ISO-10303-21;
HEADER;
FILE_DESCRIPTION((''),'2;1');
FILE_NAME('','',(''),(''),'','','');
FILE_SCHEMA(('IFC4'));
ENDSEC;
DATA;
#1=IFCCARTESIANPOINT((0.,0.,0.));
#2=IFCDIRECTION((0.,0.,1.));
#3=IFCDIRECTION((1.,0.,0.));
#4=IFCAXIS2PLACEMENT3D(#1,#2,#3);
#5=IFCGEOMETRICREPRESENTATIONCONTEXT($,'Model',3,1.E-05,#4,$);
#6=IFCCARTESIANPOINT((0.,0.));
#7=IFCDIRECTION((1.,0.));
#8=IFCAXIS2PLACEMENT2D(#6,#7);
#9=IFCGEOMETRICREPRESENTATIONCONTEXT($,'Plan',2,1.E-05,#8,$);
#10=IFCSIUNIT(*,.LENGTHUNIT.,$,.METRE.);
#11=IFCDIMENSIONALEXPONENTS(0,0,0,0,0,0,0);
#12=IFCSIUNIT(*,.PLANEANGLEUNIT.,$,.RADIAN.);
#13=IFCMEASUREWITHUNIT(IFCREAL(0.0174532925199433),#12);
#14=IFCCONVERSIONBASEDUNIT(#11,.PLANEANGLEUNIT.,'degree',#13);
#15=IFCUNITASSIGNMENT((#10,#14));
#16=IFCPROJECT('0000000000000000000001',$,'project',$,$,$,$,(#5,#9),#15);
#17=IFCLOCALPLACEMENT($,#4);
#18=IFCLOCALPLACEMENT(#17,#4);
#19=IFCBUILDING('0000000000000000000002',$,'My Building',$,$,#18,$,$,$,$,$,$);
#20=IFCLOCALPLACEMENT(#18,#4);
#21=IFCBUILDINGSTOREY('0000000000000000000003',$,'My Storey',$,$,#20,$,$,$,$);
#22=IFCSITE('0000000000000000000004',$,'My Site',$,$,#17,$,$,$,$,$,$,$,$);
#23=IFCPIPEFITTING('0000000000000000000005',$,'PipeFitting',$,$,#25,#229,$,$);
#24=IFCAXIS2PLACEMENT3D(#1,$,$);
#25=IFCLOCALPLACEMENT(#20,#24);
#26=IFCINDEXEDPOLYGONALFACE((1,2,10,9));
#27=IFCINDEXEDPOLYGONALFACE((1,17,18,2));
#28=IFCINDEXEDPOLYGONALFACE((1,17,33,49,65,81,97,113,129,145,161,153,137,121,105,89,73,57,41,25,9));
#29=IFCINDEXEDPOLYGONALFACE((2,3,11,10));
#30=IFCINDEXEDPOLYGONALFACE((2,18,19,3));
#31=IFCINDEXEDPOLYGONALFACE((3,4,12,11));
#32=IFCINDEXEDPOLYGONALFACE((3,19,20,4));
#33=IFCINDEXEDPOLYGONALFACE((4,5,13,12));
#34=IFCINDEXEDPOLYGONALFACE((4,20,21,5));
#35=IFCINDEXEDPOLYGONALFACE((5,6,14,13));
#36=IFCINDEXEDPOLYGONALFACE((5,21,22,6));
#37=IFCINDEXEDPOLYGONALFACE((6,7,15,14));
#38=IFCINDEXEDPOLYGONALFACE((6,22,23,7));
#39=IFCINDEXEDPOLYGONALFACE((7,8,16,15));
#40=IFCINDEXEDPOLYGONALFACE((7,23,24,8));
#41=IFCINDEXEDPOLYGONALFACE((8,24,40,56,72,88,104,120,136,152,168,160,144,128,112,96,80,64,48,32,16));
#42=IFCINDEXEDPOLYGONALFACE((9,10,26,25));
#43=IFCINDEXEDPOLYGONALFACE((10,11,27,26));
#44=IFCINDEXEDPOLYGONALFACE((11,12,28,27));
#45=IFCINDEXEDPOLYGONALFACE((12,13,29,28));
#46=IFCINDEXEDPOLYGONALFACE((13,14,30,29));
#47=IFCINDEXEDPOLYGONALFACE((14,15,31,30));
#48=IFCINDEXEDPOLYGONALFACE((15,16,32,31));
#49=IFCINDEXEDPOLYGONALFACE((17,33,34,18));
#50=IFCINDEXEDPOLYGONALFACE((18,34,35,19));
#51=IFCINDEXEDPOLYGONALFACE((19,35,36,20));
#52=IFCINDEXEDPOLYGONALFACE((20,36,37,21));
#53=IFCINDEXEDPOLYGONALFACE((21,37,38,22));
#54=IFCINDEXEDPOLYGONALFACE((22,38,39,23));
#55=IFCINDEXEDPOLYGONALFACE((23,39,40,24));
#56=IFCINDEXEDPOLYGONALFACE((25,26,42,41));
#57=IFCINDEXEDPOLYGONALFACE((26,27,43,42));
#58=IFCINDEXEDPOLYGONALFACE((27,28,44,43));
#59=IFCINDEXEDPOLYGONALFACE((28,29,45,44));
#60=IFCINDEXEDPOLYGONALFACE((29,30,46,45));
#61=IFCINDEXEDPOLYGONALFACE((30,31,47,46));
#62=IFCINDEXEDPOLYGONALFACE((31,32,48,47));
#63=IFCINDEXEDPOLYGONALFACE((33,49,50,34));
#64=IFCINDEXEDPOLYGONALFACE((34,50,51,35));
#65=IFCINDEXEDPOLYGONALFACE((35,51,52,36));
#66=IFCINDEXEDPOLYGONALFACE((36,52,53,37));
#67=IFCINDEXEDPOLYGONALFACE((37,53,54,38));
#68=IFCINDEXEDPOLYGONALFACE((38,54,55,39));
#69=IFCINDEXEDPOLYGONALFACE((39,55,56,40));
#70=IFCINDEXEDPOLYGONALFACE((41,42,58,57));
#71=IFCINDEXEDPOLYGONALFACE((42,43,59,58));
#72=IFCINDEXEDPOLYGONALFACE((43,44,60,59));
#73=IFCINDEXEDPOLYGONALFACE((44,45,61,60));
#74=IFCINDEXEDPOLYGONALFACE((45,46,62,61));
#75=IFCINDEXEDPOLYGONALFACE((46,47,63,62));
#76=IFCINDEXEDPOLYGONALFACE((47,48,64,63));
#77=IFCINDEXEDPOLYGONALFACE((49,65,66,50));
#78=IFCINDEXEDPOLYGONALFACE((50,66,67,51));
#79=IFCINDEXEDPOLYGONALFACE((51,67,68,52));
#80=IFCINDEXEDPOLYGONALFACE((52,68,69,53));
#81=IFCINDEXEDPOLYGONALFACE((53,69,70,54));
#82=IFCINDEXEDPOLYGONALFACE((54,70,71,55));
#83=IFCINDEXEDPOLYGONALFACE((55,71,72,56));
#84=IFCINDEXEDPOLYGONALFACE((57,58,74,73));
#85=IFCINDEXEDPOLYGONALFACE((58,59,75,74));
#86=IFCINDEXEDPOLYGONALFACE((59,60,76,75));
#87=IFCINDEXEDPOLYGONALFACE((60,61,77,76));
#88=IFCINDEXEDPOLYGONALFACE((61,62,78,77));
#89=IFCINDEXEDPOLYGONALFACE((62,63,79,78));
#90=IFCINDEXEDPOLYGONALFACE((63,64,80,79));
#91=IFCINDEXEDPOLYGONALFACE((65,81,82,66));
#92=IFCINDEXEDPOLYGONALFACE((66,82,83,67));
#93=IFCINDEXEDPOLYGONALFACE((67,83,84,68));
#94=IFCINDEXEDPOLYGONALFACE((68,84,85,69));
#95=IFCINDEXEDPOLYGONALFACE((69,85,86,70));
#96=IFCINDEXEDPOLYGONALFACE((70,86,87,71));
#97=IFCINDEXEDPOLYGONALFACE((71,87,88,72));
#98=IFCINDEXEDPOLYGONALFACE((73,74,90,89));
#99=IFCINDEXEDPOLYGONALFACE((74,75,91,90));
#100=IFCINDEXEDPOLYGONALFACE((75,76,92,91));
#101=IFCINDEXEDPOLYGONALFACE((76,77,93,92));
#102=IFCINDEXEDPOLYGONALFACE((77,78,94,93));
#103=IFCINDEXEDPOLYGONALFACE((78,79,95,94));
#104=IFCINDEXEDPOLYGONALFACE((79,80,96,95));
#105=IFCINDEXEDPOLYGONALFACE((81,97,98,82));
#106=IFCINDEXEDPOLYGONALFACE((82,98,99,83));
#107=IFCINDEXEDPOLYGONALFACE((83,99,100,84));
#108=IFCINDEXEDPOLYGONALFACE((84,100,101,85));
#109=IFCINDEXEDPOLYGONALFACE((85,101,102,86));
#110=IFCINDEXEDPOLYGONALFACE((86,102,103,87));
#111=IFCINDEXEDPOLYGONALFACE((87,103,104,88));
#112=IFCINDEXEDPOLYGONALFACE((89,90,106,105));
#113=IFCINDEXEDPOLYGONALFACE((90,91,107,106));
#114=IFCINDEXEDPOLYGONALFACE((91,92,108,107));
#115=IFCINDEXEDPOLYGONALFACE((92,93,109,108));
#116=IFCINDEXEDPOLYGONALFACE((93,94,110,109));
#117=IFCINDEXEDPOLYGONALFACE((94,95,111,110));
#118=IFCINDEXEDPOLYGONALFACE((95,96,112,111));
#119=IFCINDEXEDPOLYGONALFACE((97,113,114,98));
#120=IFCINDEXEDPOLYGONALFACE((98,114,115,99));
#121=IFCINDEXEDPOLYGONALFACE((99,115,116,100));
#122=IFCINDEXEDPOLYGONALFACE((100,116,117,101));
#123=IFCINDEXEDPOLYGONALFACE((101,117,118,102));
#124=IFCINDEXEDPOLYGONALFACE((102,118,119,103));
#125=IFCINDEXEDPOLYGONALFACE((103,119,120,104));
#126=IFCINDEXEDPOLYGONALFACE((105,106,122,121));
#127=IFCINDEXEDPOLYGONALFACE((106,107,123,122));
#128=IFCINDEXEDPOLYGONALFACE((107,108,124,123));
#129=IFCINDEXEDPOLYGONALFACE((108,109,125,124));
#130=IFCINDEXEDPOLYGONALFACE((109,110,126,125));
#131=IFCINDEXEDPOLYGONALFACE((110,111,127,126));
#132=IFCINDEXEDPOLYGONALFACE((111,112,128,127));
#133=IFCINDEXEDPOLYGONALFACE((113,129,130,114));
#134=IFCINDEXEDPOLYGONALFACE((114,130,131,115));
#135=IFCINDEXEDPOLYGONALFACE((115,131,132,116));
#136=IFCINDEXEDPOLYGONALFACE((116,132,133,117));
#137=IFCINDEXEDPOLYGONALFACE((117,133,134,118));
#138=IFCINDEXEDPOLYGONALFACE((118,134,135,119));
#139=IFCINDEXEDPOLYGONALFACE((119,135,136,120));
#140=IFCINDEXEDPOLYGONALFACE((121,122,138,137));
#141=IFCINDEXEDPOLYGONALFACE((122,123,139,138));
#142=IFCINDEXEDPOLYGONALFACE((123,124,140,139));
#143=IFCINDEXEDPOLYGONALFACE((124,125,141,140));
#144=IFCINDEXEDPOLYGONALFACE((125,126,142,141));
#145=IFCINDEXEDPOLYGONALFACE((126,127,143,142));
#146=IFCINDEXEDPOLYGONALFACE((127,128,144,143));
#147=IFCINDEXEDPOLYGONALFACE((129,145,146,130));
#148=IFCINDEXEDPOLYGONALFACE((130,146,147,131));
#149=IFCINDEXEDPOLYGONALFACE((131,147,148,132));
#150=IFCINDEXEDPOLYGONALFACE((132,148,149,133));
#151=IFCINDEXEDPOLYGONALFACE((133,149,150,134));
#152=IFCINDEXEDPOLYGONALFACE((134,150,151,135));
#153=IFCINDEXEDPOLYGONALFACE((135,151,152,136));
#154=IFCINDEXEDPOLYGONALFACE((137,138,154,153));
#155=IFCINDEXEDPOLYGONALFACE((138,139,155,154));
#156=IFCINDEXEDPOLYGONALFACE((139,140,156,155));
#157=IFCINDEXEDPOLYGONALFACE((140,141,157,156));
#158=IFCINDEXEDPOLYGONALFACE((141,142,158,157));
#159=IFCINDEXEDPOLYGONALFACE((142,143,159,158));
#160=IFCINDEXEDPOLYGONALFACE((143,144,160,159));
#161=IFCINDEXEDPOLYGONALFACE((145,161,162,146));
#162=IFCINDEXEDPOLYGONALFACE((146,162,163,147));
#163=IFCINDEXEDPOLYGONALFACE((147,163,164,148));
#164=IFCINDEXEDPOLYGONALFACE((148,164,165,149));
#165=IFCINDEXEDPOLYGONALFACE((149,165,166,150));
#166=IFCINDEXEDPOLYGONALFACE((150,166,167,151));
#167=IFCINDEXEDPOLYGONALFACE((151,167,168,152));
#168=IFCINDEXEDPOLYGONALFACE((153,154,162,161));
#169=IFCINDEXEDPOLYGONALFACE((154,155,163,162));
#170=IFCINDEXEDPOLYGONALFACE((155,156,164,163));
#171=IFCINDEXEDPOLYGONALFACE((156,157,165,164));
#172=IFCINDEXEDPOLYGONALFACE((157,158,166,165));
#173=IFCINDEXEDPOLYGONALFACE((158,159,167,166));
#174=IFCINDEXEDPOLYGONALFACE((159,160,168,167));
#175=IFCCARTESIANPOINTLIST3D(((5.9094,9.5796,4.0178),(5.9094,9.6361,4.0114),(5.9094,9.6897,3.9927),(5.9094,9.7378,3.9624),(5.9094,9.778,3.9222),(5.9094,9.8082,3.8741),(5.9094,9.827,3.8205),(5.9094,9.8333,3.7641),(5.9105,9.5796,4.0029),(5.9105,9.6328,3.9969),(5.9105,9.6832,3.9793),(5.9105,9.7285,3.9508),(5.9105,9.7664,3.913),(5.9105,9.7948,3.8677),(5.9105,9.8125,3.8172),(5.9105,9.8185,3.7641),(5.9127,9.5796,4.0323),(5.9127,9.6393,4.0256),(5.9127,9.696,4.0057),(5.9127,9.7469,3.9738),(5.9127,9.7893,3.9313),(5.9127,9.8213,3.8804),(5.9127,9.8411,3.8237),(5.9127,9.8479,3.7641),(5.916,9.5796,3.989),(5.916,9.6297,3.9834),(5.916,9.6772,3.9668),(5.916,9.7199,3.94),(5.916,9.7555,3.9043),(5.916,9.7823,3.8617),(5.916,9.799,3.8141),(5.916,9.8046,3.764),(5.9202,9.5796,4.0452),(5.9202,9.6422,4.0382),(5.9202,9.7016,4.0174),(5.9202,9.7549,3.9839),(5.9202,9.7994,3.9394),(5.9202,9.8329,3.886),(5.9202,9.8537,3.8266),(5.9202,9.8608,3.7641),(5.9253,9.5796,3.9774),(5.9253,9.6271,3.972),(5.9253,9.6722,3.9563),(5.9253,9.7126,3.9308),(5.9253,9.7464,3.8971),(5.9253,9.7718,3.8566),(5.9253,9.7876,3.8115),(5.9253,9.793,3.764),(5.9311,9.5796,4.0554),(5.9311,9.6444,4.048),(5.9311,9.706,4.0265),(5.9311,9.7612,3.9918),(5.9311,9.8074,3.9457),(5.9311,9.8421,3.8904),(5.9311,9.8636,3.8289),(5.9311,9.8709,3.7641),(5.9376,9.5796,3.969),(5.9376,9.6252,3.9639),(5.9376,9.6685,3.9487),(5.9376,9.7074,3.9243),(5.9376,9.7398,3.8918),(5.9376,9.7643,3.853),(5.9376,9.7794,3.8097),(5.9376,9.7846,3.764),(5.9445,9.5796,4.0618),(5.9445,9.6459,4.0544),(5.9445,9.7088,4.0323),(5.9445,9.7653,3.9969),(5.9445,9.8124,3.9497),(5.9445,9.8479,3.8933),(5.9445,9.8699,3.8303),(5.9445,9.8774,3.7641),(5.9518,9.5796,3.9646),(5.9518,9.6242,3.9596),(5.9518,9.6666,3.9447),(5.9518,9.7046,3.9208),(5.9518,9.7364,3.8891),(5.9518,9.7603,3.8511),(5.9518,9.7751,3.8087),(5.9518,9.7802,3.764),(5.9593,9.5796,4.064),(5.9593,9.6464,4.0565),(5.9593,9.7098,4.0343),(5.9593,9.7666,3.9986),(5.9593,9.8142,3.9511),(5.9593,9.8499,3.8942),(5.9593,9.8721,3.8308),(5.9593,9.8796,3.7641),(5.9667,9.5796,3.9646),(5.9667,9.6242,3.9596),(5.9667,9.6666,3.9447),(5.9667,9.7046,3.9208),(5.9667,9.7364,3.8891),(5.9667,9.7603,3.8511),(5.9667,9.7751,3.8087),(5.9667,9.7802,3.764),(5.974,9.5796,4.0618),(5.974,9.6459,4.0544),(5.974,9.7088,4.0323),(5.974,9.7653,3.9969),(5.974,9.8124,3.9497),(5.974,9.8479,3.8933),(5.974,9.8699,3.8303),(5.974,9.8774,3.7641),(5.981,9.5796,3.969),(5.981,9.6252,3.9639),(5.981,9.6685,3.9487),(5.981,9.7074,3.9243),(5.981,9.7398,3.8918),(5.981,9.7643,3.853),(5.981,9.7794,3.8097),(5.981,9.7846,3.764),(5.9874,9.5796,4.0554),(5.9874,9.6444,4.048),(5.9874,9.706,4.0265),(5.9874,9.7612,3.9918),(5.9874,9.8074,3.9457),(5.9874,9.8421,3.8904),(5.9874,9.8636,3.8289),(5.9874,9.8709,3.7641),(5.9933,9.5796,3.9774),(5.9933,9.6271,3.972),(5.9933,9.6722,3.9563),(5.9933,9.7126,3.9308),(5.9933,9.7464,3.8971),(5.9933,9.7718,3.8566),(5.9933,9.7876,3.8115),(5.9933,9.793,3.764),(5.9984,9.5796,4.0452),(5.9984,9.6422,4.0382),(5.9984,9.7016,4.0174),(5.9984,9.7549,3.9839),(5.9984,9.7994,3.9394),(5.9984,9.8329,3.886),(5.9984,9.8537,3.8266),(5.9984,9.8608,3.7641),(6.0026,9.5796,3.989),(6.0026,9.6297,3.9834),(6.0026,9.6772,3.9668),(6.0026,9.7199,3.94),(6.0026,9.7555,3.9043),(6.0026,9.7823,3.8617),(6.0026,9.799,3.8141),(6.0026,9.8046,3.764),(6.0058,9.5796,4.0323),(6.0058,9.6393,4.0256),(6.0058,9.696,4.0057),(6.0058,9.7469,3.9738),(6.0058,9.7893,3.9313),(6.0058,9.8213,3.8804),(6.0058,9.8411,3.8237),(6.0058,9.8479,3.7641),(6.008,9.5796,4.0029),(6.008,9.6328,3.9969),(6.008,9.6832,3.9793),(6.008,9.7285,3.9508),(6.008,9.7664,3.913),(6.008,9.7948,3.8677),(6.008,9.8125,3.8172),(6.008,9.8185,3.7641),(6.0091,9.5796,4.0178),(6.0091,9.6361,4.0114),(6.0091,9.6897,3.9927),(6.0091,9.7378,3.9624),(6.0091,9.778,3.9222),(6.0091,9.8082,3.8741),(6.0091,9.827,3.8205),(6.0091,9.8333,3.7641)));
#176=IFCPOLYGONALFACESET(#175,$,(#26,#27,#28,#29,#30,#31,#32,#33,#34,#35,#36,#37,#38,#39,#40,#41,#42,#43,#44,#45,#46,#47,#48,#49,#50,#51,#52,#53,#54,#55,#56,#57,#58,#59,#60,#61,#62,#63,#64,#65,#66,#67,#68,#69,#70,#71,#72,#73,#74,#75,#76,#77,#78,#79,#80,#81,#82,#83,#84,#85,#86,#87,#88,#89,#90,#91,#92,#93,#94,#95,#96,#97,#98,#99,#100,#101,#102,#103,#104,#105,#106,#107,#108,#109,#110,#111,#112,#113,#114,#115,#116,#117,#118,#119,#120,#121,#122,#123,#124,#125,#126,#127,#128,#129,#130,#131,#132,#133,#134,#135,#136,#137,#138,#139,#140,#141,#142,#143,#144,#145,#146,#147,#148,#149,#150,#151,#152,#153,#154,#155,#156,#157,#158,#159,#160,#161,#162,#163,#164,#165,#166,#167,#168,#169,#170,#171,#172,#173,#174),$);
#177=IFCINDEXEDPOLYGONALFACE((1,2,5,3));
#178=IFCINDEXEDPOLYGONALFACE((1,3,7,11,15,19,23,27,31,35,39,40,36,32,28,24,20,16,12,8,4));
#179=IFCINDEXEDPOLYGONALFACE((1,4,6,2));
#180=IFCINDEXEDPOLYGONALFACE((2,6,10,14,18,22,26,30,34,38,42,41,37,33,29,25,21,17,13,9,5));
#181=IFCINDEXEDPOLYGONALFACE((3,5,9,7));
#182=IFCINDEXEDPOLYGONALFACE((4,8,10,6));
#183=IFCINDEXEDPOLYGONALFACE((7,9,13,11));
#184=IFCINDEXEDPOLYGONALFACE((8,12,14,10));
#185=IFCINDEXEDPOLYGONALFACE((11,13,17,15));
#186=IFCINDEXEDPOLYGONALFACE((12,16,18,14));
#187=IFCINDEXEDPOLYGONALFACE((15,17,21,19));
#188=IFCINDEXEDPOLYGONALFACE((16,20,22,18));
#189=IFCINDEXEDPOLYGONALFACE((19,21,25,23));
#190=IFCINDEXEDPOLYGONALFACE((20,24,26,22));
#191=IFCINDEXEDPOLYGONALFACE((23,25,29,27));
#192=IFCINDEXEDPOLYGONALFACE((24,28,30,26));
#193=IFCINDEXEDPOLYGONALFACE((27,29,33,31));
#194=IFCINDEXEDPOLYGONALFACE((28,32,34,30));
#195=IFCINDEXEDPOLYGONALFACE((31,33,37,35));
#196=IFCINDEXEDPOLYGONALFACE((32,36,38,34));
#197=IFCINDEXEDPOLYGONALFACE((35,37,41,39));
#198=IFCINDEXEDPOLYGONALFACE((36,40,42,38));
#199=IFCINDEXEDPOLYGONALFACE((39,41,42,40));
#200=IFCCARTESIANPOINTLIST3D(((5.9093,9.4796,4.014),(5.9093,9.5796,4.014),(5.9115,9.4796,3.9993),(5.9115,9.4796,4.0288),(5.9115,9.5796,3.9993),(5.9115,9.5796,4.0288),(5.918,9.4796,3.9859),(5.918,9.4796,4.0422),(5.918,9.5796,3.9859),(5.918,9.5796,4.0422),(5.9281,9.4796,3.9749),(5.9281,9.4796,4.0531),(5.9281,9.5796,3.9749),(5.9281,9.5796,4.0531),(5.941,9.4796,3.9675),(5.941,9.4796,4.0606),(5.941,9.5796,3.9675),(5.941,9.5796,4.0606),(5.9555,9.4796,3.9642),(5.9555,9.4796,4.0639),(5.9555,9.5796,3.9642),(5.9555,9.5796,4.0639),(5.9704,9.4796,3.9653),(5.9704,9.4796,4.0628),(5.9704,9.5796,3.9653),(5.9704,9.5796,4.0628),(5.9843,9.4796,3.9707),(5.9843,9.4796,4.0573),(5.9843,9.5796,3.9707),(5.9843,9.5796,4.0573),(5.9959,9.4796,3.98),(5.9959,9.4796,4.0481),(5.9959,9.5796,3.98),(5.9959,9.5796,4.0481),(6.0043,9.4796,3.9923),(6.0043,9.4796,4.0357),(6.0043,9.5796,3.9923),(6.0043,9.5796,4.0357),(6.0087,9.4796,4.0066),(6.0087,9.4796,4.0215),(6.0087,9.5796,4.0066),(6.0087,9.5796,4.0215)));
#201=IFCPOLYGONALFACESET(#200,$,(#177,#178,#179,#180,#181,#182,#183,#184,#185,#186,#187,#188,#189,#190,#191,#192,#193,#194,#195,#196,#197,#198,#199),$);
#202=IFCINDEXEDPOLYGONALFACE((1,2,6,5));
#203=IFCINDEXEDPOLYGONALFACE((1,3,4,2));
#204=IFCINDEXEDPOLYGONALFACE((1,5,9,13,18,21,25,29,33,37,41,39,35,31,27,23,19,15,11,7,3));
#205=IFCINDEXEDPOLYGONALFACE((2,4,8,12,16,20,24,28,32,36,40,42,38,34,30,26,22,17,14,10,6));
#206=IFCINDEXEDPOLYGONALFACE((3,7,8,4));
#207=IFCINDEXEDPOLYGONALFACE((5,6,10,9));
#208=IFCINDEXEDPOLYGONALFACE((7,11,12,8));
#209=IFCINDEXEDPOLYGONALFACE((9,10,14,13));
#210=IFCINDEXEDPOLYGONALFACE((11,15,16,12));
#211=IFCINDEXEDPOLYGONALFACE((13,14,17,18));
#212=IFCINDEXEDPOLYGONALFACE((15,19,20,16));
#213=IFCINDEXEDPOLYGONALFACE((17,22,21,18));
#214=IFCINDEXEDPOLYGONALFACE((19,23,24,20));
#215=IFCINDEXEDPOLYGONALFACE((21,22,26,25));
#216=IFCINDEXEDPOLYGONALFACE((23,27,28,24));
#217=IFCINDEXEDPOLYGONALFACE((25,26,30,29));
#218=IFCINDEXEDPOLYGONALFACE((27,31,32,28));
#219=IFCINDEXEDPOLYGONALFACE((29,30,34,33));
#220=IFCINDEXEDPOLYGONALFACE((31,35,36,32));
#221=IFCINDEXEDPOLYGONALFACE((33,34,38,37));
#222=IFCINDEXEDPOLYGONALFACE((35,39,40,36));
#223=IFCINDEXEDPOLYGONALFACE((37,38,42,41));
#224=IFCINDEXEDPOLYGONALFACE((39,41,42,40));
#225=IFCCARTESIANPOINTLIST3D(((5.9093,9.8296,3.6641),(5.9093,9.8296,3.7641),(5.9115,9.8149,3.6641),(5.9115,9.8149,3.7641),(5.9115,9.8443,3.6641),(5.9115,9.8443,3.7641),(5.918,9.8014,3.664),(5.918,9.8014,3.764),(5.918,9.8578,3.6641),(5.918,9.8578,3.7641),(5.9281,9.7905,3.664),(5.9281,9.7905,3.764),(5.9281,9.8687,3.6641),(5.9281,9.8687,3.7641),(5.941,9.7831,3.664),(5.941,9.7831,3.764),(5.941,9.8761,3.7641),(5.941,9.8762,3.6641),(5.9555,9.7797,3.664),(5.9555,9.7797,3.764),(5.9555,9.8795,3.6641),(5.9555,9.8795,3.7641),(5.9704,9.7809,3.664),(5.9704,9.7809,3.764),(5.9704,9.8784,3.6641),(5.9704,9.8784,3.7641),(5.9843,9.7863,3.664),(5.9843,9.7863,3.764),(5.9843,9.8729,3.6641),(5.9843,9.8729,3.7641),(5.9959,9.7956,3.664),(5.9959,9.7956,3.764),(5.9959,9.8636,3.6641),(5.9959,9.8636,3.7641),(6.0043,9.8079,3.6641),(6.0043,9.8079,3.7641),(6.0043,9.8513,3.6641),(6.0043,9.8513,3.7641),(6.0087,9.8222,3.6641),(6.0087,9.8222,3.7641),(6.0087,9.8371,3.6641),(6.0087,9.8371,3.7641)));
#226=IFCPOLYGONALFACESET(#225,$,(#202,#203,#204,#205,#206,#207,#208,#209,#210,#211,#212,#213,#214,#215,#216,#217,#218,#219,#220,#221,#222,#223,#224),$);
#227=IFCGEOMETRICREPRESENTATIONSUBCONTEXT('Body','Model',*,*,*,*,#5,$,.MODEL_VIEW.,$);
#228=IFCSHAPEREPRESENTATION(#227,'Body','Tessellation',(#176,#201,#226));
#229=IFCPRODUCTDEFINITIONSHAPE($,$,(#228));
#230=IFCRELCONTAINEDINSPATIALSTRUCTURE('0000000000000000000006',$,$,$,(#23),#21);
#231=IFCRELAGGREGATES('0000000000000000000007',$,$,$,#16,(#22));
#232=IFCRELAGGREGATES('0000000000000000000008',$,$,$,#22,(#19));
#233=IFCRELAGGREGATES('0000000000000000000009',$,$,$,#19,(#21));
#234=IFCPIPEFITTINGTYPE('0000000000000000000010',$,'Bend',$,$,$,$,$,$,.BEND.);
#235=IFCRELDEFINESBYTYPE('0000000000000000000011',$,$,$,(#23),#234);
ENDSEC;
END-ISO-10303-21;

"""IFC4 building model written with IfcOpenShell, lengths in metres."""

from ifc_helpers import new_model, entity, si_unit, converted_unit, frame, origin_with_axes, origin_2d_with_axis, place, context, subcontext, project, spatial, circle, extrude, source, transform, mapped, type_object, type_shapes, element, save


model = new_model("IFC4")

# Units and contexts
model_context = context("Model", 3, precision=1e-05, world=origin_with_axes())
plan_context = context("Plan", 2, precision=1e-05, world=origin_2d_with_axis())
body_context = subcontext(model_context, "Body", "Model", "MODEL_VIEW")
ifc_project = project(units=[si_unit("LENGTHUNIT", "METRE"), converted_unit("PLANEANGLEUNIT", "degree", entity("IfcReal", 0.0174532925199433), si_unit("PLANEANGLEUNIT", "RADIAN"), dimensions=[0, 0, 0, 0, 0, 0, 0])], contexts=[model_context, plan_context])

# Site, building, storey
site_placement = place(None, origin_with_axes())
site = spatial("IfcSite", under=ifc_project, at=site_placement, Name="My Site")
building_placement = place(site_placement, origin_with_axes())
building = spatial("IfcBuilding", under=site, at=building_placement, Name="My Building")
storey_placement = place(building_placement, origin_with_axes())
storey = spatial("IfcBuildingStorey", under=building, at=storey_placement, Name="My Storey")

# Pipe fitting
pipe_fitting_type_1 = type_object("IfcPipeFittingType", Name="Bend", PredefinedType="BEND")
shared_shape_1 = source(origin_with_axes(), body_context, "Body", "SolidModel", [
    entity("IfcSweptDiskSolid", entity("IfcIndexedPolyCurve", entity("IfcCartesianPointList3D", [[0.0, 0.0, 0.1], [0.0, -0.0732, 0.2768], [0.0, -0.25, 0.35]]), [entity("IfcArcIndex", [1, 2, 3])]), 0.05),
    extrude(circle(Radius=0.05), origin_with_axes(), (0.0, 0.0, 1.0), 0.1),
    extrude(circle(Radius=0.05), frame((0.0, -0.25, 0.35), z_axis=(0.0, -1.0, 0.000038), x_axis=(1.0, 0.0, 0.0)), (0.0, 0.0, 1.0), 0.1),
])
type_shapes(pipe_fitting_type_1, [shared_shape_1])
for number, where, z_axis, x_axis, name in (
    (1, (5.9593, 9.4796, 4.014), (0.0, 1.0, 0.0), (-1.0, 0.0, 0.0), "PipeFitting"),
):
    element("IfcPipeFitting", number, at=place(storey_placement, frame(where, z_axis=z_axis, x_axis=x_axis)), inside=storey, type_object=pipe_fitting_type_1, Name=name, context=body_context, shape_type="MappedRepresentation", body=[
        mapped(shared_shape_1, transform((0.0, 0.0, 0.0), x_axis=(1.0, 0.0, 0.0), y_axis=(0.0, 1.0, 0.0), z_axis=(0.0, 0.0, 1.0), scale=1.0)),
    ])

save(model, "model.ifc")
